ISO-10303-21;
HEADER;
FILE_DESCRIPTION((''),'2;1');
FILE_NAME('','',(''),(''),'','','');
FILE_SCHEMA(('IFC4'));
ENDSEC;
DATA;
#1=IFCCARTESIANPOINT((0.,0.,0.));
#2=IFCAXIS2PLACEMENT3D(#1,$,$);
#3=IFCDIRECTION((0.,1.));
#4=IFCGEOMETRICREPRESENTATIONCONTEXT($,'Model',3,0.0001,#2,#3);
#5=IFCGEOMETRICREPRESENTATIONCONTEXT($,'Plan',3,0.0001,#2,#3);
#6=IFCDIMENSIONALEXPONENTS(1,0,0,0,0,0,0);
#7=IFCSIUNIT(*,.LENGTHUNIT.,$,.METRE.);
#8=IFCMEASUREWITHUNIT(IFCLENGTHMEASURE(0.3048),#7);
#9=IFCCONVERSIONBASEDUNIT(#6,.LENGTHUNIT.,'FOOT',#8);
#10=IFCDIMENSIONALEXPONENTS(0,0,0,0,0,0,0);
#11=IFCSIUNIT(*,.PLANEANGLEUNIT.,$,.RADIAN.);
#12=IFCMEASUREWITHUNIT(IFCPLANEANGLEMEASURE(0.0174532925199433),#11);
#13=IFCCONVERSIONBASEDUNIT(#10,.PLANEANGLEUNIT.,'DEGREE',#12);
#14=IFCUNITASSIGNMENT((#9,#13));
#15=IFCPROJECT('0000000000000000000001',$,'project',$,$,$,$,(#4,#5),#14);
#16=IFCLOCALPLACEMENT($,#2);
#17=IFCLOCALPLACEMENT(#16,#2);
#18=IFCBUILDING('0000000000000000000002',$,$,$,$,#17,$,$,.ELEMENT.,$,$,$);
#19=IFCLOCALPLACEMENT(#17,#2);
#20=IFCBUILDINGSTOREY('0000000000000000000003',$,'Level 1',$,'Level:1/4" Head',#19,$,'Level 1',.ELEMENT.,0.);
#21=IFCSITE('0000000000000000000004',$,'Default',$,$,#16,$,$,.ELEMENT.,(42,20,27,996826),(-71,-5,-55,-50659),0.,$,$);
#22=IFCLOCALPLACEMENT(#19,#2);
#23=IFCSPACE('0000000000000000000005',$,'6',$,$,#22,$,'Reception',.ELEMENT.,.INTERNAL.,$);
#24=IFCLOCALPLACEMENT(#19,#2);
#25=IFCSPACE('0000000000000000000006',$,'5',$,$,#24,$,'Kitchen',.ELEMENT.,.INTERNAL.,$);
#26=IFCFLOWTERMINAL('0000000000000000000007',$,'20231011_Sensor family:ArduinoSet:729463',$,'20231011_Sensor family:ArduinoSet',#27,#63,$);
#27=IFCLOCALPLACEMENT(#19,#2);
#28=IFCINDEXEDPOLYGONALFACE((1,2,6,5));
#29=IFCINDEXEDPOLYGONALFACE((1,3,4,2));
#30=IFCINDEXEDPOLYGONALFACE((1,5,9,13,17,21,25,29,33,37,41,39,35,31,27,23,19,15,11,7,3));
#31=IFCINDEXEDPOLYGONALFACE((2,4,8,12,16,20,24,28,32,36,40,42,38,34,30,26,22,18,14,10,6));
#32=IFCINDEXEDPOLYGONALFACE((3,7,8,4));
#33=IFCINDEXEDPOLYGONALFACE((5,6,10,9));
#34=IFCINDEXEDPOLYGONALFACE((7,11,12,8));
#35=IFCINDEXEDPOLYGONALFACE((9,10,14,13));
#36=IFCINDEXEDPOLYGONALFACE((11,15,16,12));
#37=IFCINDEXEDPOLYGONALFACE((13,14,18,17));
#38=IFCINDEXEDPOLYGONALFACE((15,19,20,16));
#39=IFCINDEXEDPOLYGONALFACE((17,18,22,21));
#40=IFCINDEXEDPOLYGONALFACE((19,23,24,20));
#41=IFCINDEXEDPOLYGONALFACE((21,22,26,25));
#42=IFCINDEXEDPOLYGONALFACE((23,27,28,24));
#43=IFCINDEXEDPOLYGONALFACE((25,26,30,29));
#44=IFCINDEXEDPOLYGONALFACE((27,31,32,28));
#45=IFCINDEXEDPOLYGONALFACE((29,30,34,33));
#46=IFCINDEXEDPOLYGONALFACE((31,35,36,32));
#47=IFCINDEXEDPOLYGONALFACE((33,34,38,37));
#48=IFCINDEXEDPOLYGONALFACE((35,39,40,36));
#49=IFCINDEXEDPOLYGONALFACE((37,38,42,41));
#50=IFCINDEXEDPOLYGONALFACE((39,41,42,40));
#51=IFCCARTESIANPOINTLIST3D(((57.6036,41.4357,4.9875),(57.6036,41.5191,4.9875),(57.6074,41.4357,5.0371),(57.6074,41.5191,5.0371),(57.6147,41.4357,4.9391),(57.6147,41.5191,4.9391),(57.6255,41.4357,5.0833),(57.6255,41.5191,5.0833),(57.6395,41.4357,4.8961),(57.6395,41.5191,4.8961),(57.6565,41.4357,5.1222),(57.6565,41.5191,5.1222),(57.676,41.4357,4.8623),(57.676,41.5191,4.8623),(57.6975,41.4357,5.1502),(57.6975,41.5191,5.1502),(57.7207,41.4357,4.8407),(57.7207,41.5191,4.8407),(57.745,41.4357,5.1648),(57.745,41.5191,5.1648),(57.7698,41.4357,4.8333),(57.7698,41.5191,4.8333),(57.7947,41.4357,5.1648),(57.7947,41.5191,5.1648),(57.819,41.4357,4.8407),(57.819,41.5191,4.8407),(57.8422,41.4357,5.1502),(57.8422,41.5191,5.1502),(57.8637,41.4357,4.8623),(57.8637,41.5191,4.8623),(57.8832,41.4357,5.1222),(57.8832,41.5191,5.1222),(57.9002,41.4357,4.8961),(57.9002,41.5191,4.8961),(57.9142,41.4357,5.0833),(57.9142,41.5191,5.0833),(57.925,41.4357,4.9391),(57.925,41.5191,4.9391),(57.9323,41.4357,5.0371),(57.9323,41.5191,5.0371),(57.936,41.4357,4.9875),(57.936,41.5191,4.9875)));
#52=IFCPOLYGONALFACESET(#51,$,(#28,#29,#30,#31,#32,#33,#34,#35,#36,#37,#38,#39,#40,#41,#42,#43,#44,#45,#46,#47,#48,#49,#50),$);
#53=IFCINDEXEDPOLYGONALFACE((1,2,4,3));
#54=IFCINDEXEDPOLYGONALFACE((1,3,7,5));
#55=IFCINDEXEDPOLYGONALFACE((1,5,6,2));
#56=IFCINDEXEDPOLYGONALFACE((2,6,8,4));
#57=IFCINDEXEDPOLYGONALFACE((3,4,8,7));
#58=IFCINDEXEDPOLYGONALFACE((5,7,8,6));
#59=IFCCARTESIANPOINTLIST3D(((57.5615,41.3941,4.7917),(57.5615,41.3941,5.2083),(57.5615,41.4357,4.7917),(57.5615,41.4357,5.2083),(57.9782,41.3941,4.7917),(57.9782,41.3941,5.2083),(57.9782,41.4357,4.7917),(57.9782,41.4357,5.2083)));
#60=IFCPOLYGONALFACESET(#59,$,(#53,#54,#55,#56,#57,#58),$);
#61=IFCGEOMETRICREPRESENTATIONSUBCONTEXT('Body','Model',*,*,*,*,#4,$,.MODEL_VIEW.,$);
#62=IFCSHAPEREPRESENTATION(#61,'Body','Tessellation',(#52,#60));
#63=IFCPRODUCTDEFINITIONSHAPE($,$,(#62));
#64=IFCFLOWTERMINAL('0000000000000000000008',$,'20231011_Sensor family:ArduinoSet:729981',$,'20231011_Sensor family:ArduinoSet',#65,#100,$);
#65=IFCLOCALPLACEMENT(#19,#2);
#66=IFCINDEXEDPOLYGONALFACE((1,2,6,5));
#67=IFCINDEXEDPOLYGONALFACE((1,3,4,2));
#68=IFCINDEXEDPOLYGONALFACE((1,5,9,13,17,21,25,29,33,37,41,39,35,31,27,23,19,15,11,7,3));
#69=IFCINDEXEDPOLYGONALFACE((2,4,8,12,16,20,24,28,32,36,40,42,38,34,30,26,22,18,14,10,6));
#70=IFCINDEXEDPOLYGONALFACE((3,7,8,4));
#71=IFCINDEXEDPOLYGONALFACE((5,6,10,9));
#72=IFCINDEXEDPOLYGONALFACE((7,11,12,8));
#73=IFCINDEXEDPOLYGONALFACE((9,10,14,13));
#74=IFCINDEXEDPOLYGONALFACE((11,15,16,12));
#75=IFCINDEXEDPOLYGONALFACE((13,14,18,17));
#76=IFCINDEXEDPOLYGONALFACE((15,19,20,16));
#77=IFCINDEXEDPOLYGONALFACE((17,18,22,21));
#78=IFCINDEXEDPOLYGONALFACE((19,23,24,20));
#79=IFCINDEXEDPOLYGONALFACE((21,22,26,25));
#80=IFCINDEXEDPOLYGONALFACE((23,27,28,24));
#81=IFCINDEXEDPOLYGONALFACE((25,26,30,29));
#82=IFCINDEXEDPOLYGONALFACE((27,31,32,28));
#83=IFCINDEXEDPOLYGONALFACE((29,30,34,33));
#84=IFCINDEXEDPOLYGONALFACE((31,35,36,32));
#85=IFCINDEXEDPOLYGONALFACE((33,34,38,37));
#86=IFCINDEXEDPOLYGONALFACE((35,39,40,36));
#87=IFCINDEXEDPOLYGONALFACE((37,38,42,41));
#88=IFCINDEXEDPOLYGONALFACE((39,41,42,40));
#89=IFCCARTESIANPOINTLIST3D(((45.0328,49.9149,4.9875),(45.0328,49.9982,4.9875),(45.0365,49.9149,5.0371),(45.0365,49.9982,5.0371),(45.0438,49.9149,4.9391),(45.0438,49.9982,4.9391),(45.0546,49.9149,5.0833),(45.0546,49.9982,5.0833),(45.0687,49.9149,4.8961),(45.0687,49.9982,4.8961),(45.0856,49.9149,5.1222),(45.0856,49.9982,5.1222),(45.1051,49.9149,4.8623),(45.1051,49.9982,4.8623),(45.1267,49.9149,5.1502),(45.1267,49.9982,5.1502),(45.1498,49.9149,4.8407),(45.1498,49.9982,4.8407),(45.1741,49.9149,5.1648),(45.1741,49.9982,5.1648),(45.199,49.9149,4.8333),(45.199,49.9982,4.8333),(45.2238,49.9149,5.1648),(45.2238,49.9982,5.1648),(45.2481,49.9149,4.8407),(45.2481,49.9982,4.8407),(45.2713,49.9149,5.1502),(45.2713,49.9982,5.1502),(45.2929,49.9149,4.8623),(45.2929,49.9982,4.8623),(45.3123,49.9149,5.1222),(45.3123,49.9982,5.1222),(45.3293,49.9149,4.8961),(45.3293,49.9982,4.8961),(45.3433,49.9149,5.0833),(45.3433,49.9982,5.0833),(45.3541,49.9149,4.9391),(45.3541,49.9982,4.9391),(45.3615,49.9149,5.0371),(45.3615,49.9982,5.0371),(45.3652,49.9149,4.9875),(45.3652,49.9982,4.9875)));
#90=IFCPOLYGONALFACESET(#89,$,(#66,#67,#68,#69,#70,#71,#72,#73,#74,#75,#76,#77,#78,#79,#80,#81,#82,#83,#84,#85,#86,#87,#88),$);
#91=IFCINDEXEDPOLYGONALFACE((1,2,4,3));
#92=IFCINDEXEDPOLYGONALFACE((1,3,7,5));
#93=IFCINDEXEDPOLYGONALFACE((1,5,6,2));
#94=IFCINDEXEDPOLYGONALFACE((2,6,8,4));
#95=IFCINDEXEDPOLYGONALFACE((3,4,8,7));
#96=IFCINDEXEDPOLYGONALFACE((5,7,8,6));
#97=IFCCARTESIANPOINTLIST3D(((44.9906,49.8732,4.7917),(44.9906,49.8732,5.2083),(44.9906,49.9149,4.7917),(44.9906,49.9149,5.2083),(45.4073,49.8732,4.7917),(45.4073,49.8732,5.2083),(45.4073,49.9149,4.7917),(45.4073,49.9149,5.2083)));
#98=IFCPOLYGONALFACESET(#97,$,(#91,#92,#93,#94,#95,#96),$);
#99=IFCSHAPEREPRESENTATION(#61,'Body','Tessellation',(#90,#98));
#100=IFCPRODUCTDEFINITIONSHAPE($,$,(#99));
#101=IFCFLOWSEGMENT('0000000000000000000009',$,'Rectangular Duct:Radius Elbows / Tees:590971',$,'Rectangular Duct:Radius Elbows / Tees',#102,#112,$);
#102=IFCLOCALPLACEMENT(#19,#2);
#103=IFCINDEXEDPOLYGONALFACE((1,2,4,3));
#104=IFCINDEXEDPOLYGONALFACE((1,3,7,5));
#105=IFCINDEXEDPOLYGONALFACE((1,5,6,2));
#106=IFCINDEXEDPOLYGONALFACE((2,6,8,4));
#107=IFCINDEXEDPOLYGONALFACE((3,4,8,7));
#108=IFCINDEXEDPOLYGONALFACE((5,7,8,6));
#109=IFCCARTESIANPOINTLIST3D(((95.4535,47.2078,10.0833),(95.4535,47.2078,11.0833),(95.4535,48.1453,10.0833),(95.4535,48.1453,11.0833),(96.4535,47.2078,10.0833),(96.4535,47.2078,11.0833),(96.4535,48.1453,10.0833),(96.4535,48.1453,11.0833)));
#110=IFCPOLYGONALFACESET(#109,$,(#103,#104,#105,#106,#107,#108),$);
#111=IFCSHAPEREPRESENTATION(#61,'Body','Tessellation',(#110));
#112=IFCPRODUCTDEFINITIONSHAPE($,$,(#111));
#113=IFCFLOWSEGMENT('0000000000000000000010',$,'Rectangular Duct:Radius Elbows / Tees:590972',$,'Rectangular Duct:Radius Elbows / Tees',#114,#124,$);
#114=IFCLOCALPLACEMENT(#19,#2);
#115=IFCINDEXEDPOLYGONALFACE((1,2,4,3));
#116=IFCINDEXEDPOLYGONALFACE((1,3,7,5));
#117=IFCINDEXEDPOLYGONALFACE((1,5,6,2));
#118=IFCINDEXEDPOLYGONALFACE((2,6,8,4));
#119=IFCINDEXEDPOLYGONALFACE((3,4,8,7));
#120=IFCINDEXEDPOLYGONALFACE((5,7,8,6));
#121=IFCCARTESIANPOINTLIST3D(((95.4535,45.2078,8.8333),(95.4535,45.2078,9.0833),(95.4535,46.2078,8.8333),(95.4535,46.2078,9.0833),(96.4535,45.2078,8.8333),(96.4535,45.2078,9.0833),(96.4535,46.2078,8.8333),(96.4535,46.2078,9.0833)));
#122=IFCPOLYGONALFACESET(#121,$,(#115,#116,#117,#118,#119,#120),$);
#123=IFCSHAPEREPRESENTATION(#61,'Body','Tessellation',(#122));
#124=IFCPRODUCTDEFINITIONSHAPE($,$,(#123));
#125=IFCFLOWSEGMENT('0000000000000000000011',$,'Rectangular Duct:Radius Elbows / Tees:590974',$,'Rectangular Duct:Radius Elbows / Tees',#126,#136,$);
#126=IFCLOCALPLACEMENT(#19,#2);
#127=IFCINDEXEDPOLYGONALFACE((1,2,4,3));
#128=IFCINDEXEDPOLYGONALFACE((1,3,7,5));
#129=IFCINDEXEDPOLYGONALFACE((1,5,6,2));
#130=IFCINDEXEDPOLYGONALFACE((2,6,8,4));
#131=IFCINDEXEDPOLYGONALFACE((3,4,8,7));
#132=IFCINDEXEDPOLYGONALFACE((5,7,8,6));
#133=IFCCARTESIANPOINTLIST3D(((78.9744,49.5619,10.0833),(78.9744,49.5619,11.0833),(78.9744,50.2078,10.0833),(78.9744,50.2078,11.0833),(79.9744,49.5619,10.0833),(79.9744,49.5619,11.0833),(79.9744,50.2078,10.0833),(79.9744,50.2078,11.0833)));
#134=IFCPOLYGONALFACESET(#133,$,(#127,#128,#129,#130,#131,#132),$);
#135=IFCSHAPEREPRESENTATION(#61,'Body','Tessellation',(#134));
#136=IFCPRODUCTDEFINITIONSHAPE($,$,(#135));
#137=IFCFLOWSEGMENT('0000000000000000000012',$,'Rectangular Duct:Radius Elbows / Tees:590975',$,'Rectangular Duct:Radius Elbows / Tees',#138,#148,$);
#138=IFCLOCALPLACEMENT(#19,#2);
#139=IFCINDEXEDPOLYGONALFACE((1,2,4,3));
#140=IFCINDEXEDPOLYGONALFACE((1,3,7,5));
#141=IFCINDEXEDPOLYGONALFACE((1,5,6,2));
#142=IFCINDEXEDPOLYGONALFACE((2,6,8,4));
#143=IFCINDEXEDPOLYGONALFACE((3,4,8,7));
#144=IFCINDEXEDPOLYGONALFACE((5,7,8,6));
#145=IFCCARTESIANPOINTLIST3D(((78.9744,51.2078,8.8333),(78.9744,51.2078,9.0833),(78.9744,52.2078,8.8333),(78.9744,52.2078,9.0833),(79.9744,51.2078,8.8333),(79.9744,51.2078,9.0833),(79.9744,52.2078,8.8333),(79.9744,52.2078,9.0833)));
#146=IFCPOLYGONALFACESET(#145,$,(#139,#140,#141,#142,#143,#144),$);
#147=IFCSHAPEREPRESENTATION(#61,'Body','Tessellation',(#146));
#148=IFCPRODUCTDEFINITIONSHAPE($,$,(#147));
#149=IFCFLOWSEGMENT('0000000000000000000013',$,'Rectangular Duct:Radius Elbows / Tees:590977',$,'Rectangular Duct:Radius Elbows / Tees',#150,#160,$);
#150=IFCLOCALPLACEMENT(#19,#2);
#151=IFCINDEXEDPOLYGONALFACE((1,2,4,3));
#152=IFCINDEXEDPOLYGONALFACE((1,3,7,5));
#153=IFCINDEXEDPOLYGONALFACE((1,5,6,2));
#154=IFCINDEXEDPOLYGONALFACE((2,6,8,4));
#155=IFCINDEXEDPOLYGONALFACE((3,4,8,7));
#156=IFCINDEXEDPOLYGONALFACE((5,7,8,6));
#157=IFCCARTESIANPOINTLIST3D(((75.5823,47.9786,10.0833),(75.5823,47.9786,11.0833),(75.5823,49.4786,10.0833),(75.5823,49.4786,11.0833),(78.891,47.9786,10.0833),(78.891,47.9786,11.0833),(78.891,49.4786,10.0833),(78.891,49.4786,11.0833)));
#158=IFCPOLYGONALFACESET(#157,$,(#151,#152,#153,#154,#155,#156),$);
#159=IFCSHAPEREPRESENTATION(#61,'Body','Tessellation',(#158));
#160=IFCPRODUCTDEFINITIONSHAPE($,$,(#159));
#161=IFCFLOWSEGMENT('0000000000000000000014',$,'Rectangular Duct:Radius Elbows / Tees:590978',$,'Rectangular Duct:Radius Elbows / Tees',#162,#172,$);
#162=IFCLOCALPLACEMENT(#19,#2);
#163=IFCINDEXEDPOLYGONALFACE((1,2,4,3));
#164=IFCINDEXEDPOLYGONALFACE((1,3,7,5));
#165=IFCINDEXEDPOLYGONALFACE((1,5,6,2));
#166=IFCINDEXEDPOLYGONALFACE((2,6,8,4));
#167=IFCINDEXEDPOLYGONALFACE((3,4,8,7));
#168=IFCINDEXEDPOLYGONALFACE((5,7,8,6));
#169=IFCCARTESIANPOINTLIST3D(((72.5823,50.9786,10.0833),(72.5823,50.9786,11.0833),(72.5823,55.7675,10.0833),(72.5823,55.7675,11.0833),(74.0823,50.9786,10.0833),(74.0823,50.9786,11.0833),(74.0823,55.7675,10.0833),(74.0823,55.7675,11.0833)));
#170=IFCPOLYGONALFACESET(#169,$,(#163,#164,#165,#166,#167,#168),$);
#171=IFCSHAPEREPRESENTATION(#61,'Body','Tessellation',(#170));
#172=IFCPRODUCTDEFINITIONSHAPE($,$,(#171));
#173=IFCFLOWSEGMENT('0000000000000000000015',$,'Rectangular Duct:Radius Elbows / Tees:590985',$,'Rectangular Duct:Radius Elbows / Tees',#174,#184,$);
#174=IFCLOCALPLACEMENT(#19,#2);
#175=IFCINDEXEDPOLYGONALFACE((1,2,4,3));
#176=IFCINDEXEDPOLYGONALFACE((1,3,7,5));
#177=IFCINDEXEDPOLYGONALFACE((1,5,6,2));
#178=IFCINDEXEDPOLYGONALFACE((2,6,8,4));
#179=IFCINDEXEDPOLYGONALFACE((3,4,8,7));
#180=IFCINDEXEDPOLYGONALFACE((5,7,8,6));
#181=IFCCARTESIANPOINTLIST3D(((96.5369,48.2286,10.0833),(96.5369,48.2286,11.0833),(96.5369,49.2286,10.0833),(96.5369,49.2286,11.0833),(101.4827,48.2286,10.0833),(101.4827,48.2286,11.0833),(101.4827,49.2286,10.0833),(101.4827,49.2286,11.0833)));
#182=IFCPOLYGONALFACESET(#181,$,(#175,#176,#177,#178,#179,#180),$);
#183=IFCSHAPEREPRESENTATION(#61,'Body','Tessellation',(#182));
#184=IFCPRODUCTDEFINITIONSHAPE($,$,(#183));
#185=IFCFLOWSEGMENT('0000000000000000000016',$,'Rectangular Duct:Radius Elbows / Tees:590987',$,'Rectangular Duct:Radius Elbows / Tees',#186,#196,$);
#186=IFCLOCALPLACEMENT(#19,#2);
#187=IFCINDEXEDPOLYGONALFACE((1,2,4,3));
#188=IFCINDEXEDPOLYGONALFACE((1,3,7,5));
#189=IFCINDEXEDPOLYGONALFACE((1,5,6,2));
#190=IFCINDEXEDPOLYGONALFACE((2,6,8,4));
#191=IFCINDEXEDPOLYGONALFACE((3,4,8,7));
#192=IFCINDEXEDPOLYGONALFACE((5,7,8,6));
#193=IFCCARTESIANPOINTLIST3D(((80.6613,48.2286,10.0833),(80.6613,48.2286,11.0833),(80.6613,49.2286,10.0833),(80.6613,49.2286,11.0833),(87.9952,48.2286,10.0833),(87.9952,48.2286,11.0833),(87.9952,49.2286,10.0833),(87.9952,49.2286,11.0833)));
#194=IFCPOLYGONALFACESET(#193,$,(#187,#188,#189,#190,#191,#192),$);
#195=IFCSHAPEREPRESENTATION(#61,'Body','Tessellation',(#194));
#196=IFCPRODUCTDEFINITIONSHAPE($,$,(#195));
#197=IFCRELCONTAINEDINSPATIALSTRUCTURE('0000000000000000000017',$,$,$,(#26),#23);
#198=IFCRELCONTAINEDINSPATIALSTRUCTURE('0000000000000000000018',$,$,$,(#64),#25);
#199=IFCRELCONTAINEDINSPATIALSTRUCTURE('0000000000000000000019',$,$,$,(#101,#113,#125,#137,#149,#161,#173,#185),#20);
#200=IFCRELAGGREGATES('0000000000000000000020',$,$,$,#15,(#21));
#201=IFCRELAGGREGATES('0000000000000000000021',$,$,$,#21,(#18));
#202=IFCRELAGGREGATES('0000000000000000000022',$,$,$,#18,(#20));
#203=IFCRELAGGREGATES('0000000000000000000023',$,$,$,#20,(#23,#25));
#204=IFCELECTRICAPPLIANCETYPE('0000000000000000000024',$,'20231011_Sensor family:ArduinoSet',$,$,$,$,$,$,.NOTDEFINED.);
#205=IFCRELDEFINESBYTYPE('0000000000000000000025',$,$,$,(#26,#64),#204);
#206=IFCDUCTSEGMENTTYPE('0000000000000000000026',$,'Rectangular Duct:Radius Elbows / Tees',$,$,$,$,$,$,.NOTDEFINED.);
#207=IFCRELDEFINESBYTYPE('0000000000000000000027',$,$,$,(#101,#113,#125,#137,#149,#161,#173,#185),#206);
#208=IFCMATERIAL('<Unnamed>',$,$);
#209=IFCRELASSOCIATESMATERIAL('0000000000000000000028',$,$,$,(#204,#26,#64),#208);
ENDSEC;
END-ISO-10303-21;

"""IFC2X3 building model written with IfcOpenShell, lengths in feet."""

from ifc_helpers import new_model, entity, si_unit, converted_unit, direction, frame, frame_2d, origin, origin_2d_with_axis, place, context, subcontext, project, spatial, rectangle, circle, extrude, source, transform, mapped, material, type_object, type_shapes, element, save


model = new_model("IFC2X3")

# Units and contexts
model_context = context("Model", 3, precision=0.0001, world=origin(), true_north=direction((0.0, 1.0)))
plan_context = context("Plan", 3, precision=0.0001, world=origin(), true_north=direction((0.0, 1.0)))
body_context = subcontext(model_context, "Body", "Model", "MODEL_VIEW")
ifc_project = project(units=[converted_unit("LENGTHUNIT", "FOOT", entity("IfcLengthMeasure", 0.3048), si_unit("LENGTHUNIT", "METRE"), dimensions=[1, 0, 0, 0, 0, 0, 0]), converted_unit("PLANEANGLEUNIT", "DEGREE", entity("IfcPlaneAngleMeasure", 0.0174532925199433), si_unit("PLANEANGLEUNIT", "RADIAN"), dimensions=[0, 0, 0, 0, 0, 0, 0])], contexts=[model_context, plan_context])

# Site, building, storey
site_placement = place(None, origin())
site = spatial("IfcSite", under=ifc_project, at=site_placement, Name="Default", CompositionType="ELEMENT", RefLatitude=(42, 20, 27, 996826), RefLongitude=(-71, -5, -55, -50659), RefElevation=0.0)
building_placement = place(site_placement, origin())
building = spatial("IfcBuilding", under=site, at=building_placement, CompositionType="ELEMENT")
storey_placement = place(building_placement, origin())
storey = spatial("IfcBuildingStorey", under=building, at=storey_placement, Name="Level 1", ObjectType="Level:1/4\" Head", LongName="Level 1", CompositionType="ELEMENT", Elevation=0.0)

# Shared definitions
space_1_placement = place(storey_placement, origin())
space_1 = spatial("IfcSpace", under=storey, at=space_1_placement, Name="6", LongName="Reception", CompositionType="ELEMENT", InteriorOrExteriorSpace="INTERNAL")

# Flow terminal
ifc_material_1 = material(Name="<Unnamed>")
electric_appliance_type = type_object("IfcElectricApplianceType", Name="20231011_Sensor family:ArduinoSet", PredefinedType="NOTDEFINED", material=ifc_material_1)
shared_shape_1 = source(origin(), body_context, "Body", "SweptSolid", [
    extrude(circle(Radius=0.1667, at=frame_2d((0.0, 0.0), x_axis=(1.0, 0.0))), frame((0.0417, 0.0, 0.0), z_axis=(1.0, 0.0, 0.0), x_axis=(0.0, 0.0, -1.0)), (0.0, 0.0, 1.0), 0.0833),
    extrude(rectangle(XDim=0.0417, YDim=0.4167, at=origin_2d_with_axis()), frame((0.0208, 0.0, -0.2083), z_axis=(0.0, 0.0, 1.0), x_axis=(-1.0, 0.0, 0.0)), (0.0, 0.0, 1.0), 0.4167),
])
type_shapes(electric_appliance_type, [shared_shape_1])
flow_terminal_1_placement = place(space_1_placement, frame((57.7698, 41.3941, 5.0), z_axis=(0.0, 0.0, 1.0), x_axis=(0.0, 1.0, 0.0)))
element("IfcFlowTerminal", 1, at=flow_terminal_1_placement, inside=space_1, type_object=electric_appliance_type, material=ifc_material_1, Name="20231011_Sensor family:ArduinoSet:729463", ObjectType="20231011_Sensor family:ArduinoSet", context=body_context, shape_type="MappedRepresentation", body=[
    mapped(shared_shape_1, transform((0.0, 0.0, 0.0), scale=1.0)),
])

# Shared definitions
space_2_placement = place(storey_placement, origin())
space_2 = spatial("IfcSpace", under=storey, at=space_2_placement, Name="5", LongName="Kitchen", CompositionType="ELEMENT", InteriorOrExteriorSpace="INTERNAL")

# Flow terminal
flow_terminal_2_placement = place(space_2_placement, frame((45.199, 49.8732, 5.0), z_axis=(0.0, 0.0, 1.0), x_axis=(0.0, 1.0, 0.0)))
element("IfcFlowTerminal", 2, at=flow_terminal_2_placement, inside=space_2, type_object=electric_appliance_type, material=ifc_material_1, Name="20231011_Sensor family:ArduinoSet:729981", ObjectType="20231011_Sensor family:ArduinoSet", context=body_context, shape_type="MappedRepresentation", body=[
    mapped(shared_shape_1, transform((0.0, 0.0, 0.0), scale=1.0)),
])

# Flow segments
duct_segment_type = type_object("IfcDuctSegmentType", Name="Rectangular Duct:Radius Elbows / Tees", PredefinedType="NOTDEFINED")
flow_segment_1_placement = place(storey_placement, origin())
element("IfcFlowSegment", 3, at=flow_segment_1_placement, inside=storey, type_object=duct_segment_type, Name="Rectangular Duct:Radius Elbows / Tees:590971", ObjectType="Rectangular Duct:Radius Elbows / Tees", context=body_context, shape_type="SweptSolid", body=[
    extrude(rectangle(XDim=0.9375, YDim=1.0, at=frame_2d((0.0, 0.0), x_axis=(1.0, 0.0))), frame((95.9535, 47.6765, 10.0833), z_axis=(0.0, 0.0, 1.0), x_axis=(0.0, -1.0, 0.0)), (0.0, 0.0, 1.0), 1.0),
])
flow_segment_2_placement = place(storey_placement, origin())
element("IfcFlowSegment", 4, at=flow_segment_2_placement, inside=storey, type_object=duct_segment_type, Name="Rectangular Duct:Radius Elbows / Tees:590972", ObjectType="Rectangular Duct:Radius Elbows / Tees", context=body_context, shape_type="SweptSolid", body=[
    extrude(rectangle(XDim=1.0, YDim=1.0, at=origin_2d_with_axis()), frame((95.9535, 45.7078, 8.8333), z_axis=(0.0, 0.0, 1.0), x_axis=(0.0, 1.0, 0.0)), (0.0, 0.0, 1.0), 0.25),
])
flow_segment_3_placement = place(storey_placement, origin())
element("IfcFlowSegment", 5, at=flow_segment_3_placement, inside=storey, type_object=duct_segment_type, Name="Rectangular Duct:Radius Elbows / Tees:590974", ObjectType="Rectangular Duct:Radius Elbows / Tees", context=body_context, shape_type="SweptSolid", body=[
    extrude(rectangle(XDim=0.6458, YDim=1.0, at=frame_2d((0.0, 0.0), x_axis=(1.0, 0.0))), frame((79.4744, 49.8849, 10.0833), z_axis=(0.0, 0.0, 1.0), x_axis=(0.0, -1.0, 0.0)), (0.0, 0.0, 1.0), 1.0),
])
flow_segment_4_placement = place(storey_placement, origin())
element("IfcFlowSegment", 6, at=flow_segment_4_placement, inside=storey, type_object=duct_segment_type, Name="Rectangular Duct:Radius Elbows / Tees:590975", ObjectType="Rectangular Duct:Radius Elbows / Tees", context=body_context, shape_type="SweptSolid", body=[
    extrude(rectangle(XDim=1.0, YDim=1.0, at=origin_2d_with_axis()), frame((79.4744, 51.7078, 8.8333), z_axis=(0.0, 0.0, 1.0), x_axis=(0.0, 1.0, 0.0)), (0.0, 0.0, 1.0), 0.25),
])
flow_segment_5_placement = place(storey_placement, origin())
element("IfcFlowSegment", 7, at=flow_segment_5_placement, inside=storey, type_object=duct_segment_type, Name="Rectangular Duct:Radius Elbows / Tees:590977", ObjectType="Rectangular Duct:Radius Elbows / Tees", context=body_context, shape_type="SweptSolid", body=[
    extrude(rectangle(XDim=3.3087, YDim=1.5, at=frame_2d((0.0, 0.0), x_axis=(1.0, 0.0))), frame((77.2367, 48.7286, 10.0833)), (0.0, 0.0, 1.0), 1.0),
])
flow_segment_6_placement = place(storey_placement, origin())
element("IfcFlowSegment", 8, at=flow_segment_6_placement, inside=storey, type_object=duct_segment_type, Name="Rectangular Duct:Radius Elbows / Tees:590978", ObjectType="Rectangular Duct:Radius Elbows / Tees", context=body_context, shape_type="SweptSolid", body=[
    extrude(rectangle(XDim=4.7889, YDim=1.5, at=frame_2d((0.0, 0.0), x_axis=(1.0, 0.0))), frame((73.3323, 53.3731, 10.0833), z_axis=(0.0, 0.0, 1.0), x_axis=(0.0, -1.0, 0.0)), (0.0, 0.0, 1.0), 1.0),
])
flow_segment_7_placement = place(storey_placement, origin())
element("IfcFlowSegment", 9, at=flow_segment_7_placement, inside=storey, type_object=duct_segment_type, Name="Rectangular Duct:Radius Elbows / Tees:590985", ObjectType="Rectangular Duct:Radius Elbows / Tees", context=body_context, shape_type="SweptSolid", body=[
    extrude(rectangle(XDim=4.9458, YDim=1.0, at=frame_2d((0.0, 0.0), x_axis=(1.0, 0.0))), frame((99.0098, 48.7286, 10.0833)), (0.0, 0.0, 1.0), 1.0),
])
flow_segment_8_placement = place(storey_placement, origin())
element("IfcFlowSegment", 10, at=flow_segment_8_placement, inside=storey, type_object=duct_segment_type, Name="Rectangular Duct:Radius Elbows / Tees:590987", ObjectType="Rectangular Duct:Radius Elbows / Tees", context=body_context, shape_type="SweptSolid", body=[
    extrude(rectangle(XDim=7.3339, YDim=1.0, at=frame_2d((0.0, 0.0), x_axis=(1.0, 0.0))), frame((84.3282, 48.7286, 10.0833)), (0.0, 0.0, 1.0), 1.0),
])

save(model, "model.ifc")
